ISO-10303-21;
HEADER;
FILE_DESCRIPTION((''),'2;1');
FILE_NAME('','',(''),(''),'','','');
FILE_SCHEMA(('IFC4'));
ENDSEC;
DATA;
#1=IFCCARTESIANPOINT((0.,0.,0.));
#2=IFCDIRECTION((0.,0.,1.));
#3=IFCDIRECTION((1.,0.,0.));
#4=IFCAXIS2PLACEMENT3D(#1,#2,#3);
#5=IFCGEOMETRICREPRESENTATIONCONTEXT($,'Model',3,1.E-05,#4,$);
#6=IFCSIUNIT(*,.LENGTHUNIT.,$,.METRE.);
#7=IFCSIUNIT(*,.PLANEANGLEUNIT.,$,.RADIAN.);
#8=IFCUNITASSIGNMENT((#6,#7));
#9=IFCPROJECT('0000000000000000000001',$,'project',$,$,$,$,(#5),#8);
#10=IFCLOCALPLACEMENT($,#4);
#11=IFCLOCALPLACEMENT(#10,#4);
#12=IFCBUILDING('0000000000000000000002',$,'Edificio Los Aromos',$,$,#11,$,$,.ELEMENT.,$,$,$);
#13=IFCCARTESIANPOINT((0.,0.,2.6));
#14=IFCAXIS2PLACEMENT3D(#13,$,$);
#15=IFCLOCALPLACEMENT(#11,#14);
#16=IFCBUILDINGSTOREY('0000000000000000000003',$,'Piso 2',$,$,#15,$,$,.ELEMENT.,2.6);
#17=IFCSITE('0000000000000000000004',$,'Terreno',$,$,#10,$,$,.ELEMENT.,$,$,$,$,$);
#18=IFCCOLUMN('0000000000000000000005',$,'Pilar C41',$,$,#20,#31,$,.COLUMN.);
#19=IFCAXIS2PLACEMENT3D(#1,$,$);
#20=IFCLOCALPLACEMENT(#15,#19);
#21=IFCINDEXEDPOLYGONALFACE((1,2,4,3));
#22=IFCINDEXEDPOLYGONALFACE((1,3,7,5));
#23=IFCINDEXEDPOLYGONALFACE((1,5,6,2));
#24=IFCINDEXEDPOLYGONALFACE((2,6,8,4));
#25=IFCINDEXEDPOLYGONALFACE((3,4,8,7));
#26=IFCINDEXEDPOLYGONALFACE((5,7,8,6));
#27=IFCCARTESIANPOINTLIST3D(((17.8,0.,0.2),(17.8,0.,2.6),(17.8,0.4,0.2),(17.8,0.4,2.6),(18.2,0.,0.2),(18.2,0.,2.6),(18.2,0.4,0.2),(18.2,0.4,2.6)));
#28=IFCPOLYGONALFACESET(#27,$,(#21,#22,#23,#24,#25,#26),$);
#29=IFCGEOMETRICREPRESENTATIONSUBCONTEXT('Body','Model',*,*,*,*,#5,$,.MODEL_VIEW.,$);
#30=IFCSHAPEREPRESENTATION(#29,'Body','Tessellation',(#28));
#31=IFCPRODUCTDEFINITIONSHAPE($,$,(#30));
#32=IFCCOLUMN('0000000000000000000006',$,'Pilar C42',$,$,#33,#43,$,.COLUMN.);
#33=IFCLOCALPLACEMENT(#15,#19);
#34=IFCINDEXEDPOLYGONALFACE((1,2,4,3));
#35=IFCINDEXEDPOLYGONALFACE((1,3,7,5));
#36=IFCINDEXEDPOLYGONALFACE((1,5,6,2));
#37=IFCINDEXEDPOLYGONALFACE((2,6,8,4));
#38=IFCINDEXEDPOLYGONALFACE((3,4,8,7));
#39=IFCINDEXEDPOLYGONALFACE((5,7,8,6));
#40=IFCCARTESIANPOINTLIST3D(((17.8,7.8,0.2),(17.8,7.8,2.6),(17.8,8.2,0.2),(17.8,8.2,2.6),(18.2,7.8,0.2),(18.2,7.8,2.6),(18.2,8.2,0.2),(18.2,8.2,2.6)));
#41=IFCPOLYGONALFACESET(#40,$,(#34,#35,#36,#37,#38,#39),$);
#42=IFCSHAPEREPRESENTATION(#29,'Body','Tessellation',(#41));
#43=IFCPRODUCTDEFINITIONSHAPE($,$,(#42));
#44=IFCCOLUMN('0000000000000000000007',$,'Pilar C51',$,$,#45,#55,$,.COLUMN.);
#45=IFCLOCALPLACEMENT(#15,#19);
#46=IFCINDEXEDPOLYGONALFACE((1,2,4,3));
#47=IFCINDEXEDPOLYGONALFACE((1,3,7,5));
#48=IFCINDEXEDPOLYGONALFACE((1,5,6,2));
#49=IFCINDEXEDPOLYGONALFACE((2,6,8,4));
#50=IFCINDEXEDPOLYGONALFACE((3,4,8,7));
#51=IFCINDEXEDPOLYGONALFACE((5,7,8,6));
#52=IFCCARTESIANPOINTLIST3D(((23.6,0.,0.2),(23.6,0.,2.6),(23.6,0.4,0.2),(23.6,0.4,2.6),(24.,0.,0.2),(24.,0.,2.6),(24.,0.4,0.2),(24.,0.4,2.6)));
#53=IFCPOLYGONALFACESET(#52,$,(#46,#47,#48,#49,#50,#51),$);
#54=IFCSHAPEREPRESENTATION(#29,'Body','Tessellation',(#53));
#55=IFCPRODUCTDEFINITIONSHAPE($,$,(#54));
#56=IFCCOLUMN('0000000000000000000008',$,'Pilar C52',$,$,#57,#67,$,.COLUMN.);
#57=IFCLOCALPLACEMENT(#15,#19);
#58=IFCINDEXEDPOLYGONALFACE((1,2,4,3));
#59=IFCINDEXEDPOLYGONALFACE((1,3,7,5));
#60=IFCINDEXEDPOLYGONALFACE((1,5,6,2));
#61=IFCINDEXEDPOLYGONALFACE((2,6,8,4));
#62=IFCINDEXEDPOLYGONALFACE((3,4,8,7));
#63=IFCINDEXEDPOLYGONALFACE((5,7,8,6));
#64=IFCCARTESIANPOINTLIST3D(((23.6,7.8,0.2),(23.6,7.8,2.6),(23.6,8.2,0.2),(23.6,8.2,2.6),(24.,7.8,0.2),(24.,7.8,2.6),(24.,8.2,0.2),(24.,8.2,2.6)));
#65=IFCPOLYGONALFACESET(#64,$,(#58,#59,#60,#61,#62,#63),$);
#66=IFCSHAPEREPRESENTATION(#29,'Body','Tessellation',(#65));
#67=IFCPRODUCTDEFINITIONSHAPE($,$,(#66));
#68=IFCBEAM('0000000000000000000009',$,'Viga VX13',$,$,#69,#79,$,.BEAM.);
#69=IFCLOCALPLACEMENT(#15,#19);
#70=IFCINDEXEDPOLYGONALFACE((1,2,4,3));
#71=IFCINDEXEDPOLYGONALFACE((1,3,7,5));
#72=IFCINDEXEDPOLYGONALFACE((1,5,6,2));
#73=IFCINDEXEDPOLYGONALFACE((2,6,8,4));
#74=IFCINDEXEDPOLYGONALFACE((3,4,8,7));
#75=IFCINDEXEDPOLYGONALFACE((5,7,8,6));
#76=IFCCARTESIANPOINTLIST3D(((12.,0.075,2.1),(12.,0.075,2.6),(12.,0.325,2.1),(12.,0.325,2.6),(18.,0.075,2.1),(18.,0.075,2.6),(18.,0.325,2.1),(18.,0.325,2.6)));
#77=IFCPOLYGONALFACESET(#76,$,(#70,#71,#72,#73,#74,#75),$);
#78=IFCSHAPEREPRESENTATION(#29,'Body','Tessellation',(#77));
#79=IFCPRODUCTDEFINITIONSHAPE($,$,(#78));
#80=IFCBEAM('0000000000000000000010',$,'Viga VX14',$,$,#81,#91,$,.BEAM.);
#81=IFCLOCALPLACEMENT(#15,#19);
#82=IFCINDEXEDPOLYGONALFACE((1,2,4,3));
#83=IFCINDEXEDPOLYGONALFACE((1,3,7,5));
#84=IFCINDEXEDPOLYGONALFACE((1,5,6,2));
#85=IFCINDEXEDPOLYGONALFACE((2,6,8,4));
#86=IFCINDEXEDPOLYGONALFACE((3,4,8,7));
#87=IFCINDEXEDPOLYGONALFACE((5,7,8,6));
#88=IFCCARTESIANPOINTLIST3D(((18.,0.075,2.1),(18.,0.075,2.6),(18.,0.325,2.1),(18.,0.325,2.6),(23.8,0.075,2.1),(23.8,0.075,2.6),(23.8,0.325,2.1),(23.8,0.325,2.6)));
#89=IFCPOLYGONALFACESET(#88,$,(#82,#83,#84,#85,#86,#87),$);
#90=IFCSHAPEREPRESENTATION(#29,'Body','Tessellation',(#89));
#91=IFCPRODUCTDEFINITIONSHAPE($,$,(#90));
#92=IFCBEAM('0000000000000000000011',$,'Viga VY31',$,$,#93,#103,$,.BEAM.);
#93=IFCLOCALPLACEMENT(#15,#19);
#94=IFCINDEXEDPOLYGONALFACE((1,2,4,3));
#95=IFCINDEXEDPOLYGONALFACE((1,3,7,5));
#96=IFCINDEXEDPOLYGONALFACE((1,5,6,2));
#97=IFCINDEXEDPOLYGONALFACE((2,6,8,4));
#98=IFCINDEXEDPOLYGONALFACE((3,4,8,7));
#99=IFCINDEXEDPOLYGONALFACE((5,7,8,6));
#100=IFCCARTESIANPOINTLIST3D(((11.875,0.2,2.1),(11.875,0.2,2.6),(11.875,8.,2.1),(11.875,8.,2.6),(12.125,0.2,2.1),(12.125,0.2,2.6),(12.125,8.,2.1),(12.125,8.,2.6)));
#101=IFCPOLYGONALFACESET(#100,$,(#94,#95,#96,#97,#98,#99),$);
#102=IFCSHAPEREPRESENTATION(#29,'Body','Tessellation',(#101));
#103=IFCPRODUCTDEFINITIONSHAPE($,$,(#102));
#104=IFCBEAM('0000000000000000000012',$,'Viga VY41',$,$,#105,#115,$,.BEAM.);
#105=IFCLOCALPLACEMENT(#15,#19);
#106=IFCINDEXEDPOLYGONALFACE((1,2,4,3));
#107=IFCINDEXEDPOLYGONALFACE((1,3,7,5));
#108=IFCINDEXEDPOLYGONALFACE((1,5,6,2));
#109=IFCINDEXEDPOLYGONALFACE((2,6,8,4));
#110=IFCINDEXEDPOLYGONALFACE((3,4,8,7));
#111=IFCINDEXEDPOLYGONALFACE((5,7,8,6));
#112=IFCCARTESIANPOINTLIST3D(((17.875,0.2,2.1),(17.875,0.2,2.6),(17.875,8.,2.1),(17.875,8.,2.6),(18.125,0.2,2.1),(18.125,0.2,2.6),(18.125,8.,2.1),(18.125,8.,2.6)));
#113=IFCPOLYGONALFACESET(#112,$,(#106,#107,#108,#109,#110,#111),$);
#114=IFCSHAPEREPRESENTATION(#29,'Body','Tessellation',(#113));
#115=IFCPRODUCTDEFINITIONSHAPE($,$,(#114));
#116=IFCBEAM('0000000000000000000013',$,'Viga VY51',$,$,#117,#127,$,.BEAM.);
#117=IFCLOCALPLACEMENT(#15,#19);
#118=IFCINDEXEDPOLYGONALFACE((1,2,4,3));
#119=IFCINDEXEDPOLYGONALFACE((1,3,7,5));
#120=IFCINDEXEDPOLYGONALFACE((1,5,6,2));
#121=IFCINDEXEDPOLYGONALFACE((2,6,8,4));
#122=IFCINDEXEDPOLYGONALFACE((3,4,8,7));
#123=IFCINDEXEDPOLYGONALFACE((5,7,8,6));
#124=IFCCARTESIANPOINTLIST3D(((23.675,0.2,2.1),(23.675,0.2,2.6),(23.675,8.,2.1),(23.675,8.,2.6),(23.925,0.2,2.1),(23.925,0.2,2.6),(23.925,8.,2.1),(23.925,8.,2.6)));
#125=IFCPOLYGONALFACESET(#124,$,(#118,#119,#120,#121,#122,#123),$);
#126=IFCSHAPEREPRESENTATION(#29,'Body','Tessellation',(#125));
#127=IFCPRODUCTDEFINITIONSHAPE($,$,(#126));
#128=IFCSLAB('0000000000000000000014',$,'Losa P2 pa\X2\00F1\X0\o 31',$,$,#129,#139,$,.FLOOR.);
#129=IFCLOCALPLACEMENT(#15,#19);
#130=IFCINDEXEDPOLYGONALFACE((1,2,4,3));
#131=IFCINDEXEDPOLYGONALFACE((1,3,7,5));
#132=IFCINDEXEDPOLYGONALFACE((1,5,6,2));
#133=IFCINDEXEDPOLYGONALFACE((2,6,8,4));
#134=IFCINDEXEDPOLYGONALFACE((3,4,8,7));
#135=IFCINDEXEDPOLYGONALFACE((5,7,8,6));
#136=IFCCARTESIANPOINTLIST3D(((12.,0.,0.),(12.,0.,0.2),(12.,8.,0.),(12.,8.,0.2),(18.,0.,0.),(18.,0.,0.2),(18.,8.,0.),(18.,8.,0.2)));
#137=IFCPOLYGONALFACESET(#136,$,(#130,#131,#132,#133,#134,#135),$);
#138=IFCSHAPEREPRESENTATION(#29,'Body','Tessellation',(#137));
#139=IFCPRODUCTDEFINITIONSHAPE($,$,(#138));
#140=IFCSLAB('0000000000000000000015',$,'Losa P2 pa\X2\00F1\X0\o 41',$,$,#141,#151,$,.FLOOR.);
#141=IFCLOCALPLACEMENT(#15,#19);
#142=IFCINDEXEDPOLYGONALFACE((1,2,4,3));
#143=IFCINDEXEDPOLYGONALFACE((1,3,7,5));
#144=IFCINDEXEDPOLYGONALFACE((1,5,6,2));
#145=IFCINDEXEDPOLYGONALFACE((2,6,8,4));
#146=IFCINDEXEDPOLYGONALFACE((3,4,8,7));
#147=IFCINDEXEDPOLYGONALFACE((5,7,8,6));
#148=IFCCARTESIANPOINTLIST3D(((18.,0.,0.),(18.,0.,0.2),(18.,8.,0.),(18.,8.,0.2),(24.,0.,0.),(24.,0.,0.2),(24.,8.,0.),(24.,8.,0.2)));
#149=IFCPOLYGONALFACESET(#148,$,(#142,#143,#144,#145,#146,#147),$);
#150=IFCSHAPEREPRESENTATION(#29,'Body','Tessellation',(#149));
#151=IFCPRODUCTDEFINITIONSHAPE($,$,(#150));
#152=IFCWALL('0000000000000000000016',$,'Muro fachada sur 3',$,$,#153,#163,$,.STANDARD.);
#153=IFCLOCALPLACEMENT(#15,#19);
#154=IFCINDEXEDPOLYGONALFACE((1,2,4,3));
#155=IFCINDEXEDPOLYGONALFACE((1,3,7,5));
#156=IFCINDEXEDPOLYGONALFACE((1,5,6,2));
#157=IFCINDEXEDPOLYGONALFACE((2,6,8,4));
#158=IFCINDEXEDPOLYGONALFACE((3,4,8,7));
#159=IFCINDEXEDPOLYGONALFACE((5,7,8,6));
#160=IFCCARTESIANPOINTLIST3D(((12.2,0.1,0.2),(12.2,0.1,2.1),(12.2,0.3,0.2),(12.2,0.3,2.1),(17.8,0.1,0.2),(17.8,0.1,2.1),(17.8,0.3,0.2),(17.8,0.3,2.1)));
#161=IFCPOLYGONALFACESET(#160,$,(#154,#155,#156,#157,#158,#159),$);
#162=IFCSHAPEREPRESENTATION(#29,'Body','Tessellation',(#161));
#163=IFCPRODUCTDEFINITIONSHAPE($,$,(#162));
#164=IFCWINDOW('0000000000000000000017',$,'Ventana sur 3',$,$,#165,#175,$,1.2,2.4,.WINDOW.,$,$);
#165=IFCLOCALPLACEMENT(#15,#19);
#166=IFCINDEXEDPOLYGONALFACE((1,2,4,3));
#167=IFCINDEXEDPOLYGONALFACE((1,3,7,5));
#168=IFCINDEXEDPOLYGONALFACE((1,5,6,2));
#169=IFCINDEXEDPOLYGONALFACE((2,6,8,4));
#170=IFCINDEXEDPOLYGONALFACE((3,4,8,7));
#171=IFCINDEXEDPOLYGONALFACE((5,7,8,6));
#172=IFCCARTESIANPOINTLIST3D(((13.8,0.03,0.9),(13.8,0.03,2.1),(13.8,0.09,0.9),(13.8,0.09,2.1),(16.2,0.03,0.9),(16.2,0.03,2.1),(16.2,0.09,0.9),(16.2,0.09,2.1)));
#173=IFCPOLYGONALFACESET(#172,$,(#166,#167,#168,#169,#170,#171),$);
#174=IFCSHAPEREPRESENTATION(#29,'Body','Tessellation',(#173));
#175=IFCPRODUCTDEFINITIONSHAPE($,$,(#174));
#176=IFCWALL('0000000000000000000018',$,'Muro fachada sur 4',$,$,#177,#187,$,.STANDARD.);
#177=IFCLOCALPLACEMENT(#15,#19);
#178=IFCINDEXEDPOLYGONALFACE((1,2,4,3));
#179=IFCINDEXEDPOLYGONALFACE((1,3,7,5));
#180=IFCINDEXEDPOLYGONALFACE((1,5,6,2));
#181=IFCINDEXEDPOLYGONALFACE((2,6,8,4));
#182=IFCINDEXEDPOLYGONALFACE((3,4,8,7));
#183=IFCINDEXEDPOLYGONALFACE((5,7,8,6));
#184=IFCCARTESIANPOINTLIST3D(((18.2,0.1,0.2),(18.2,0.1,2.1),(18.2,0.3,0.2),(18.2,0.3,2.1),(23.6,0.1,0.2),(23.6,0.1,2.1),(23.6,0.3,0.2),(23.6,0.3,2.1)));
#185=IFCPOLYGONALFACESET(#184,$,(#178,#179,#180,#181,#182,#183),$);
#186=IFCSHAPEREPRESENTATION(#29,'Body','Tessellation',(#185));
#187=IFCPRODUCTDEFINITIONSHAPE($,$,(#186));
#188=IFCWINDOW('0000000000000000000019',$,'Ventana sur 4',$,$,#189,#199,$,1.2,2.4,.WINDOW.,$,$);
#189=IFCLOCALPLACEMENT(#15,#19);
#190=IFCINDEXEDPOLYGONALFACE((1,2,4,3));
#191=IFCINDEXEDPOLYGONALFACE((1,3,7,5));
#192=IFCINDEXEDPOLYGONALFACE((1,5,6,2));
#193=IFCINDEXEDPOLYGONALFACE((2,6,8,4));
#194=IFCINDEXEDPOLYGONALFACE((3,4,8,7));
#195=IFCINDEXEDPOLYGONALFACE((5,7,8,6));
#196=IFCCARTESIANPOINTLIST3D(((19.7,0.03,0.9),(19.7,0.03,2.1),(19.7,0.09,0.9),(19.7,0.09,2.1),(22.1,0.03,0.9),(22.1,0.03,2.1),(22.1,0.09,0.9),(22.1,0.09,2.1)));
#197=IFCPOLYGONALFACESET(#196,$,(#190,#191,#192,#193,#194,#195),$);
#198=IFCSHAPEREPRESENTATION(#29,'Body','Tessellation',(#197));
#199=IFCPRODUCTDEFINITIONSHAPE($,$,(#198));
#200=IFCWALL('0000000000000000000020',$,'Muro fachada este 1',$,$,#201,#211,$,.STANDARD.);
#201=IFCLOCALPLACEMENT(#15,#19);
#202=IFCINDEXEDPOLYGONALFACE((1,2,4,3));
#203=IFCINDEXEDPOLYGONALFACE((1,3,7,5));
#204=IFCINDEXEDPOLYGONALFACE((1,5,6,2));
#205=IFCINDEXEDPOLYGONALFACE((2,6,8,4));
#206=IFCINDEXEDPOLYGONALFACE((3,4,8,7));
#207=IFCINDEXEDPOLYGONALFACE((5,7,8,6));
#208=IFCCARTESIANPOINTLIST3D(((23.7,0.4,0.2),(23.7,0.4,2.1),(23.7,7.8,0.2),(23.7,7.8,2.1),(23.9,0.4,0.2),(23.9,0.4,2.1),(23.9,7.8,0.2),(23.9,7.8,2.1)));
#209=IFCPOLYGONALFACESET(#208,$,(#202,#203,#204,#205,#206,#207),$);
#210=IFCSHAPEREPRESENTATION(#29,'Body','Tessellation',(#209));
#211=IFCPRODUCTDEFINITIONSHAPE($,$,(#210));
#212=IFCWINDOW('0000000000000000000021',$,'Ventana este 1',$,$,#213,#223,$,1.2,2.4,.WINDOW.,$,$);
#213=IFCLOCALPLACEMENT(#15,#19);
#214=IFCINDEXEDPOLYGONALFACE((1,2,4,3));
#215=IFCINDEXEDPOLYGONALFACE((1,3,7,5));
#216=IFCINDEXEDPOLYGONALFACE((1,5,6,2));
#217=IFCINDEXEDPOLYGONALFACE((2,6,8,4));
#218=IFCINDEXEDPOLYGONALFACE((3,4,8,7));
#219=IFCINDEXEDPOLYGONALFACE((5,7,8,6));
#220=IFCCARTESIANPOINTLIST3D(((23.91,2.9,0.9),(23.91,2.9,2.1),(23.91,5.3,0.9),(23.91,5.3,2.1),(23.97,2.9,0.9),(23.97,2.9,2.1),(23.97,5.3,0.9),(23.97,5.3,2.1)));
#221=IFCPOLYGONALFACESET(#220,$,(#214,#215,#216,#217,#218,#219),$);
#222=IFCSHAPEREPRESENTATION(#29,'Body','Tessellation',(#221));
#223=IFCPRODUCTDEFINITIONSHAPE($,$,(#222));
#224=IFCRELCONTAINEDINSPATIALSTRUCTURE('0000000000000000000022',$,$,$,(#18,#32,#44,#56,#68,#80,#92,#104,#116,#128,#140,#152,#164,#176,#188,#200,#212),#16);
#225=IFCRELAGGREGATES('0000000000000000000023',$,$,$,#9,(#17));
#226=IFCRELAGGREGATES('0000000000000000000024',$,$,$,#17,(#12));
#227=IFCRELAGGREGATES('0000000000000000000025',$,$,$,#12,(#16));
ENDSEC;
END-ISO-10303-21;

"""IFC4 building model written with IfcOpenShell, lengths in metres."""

from ifc_helpers import new_model, si_unit, frame, frame_2d, origin_with_axes, place, context, subcontext, project, spatial, rectangle, extrude, element, save


model = new_model("IFC4")

# Units and contexts
model_context = context("Model", 3, precision=1e-05, world=origin_with_axes())
body_context = subcontext(model_context, "Body", "Model", "MODEL_VIEW")
ifc_project = project(units=[si_unit("LENGTHUNIT", "METRE"), si_unit("PLANEANGLEUNIT", "RADIAN")], contexts=[model_context])

# Site, building, storey
site_placement = place(None, origin_with_axes())
site = spatial("IfcSite", under=ifc_project, at=site_placement, Name="Terreno", CompositionType="ELEMENT")
building_placement = place(site_placement, origin_with_axes())
building = spatial("IfcBuilding", under=site, at=building_placement, Name="Edificio Los Aromos", CompositionType="ELEMENT")
storey_placement = place(building_placement, frame((0.0, 0.0, 2.6)))
storey = spatial("IfcBuildingStorey", under=building, at=storey_placement, Name="Piso 2", CompositionType="ELEMENT", Elevation=2.6)

# Columns
for number, where, name in (
    (1, (17.8, 0.0, 0.2), "Pilar C41"),
    (2, (17.8, 7.8, 0.2), "Pilar C42"),
    (3, (23.6, 0.0, 0.2), "Pilar C51"),
    (4, (23.6, 7.8, 0.2), "Pilar C52"),
):
    element("IfcColumn", number, at=place(storey_placement, frame(where)), inside=storey, Name=name, PredefinedType="COLUMN", context=body_context, shape_type="SweptSolid", body=[
        extrude(rectangle(XDim=0.4, YDim=0.4, at=frame_2d((0.2, 0.2))), origin_with_axes(), (0.0, 0.0, 1.0), 2.4),
    ])

# Beams
beam_1_placement = place(storey_placement, frame((12.0, 0.075, 2.1)))
element("IfcBeam", 5, at=beam_1_placement, inside=storey, Name="Viga VX13", PredefinedType="BEAM", context=body_context, shape_type="SweptSolid", body=[
    extrude(rectangle(XDim=6.0, YDim=0.25, at=frame_2d((3.0, 0.125))), origin_with_axes(), (0.0, 0.0, 1.0), 0.5),
])
beam_2_placement = place(storey_placement, frame((18.0, 0.075, 2.1)))
element("IfcBeam", 6, at=beam_2_placement, inside=storey, Name="Viga VX14", PredefinedType="BEAM", context=body_context, shape_type="SweptSolid", body=[
    extrude(rectangle(XDim=5.8, YDim=0.25, at=frame_2d((2.9, 0.125))), origin_with_axes(), (0.0, 0.0, 1.0), 0.5),
])
for number, where, name in (
    (7, (11.875, 0.2, 2.1), "Viga VY31"),
    (8, (17.875, 0.2, 2.1), "Viga VY41"),
    (9, (23.675, 0.2, 2.1), "Viga VY51"),
):
    element("IfcBeam", number, at=place(storey_placement, frame(where)), inside=storey, Name=name, PredefinedType="BEAM", context=body_context, shape_type="SweptSolid", body=[
        extrude(rectangle(XDim=0.25, YDim=7.8, at=frame_2d((0.125, 3.9))), origin_with_axes(), (0.0, 0.0, 1.0), 0.5),
    ])

# Slabs
for number, where, name in (
    (10, (12.0, 0.0, 0.0), "Losa P2 paño 31"),
    (11, (18.0, 0.0, 0.0), "Losa P2 paño 41"),
):
    element("IfcSlab", number, at=place(storey_placement, frame(where)), inside=storey, Name=name, PredefinedType="FLOOR", context=body_context, shape_type="SweptSolid", body=[
        extrude(rectangle(XDim=6.0, YDim=8.0, at=frame_2d((3.0, 4.0))), origin_with_axes(), (0.0, 0.0, 1.0), 0.2),
    ])

# Wall
wall_1_placement = place(storey_placement, frame((12.2, 0.1, 0.2)))
element("IfcWall", 12, at=wall_1_placement, inside=storey, Name="Muro fachada sur 3", PredefinedType="STANDARD", context=body_context, shape_type="SweptSolid", body=[
    extrude(rectangle(XDim=5.6, YDim=0.2, at=frame_2d((2.8, 0.1))), origin_with_axes(), (0.0, 0.0, 1.0), 1.9),
])

# Window
window_1_placement = place(storey_placement, frame((13.8, 0.03, 0.9)))
element("IfcWindow", 13, at=window_1_placement, inside=storey, Name="Ventana sur 3", OverallHeight=1.2, OverallWidth=2.4, PredefinedType="WINDOW", context=body_context, shape_type="SweptSolid", body=[
    extrude(rectangle(XDim=2.4, YDim=0.06, at=frame_2d((1.2, 0.03))), origin_with_axes(), (0.0, 0.0, 1.0), 1.2),
])

# Wall
wall_2_placement = place(storey_placement, frame((18.2, 0.1, 0.2)))
element("IfcWall", 14, at=wall_2_placement, inside=storey, Name="Muro fachada sur 4", PredefinedType="STANDARD", context=body_context, shape_type="SweptSolid", body=[
    extrude(rectangle(XDim=5.4, YDim=0.2, at=frame_2d((2.7, 0.1))), origin_with_axes(), (0.0, 0.0, 1.0), 1.9),
])

# Window
window_2_placement = place(storey_placement, frame((19.7, 0.03, 0.9)))
element("IfcWindow", 15, at=window_2_placement, inside=storey, Name="Ventana sur 4", OverallHeight=1.2, OverallWidth=2.4, PredefinedType="WINDOW", context=body_context, shape_type="SweptSolid", body=[
    extrude(rectangle(XDim=2.4, YDim=0.06, at=frame_2d((1.2, 0.03))), origin_with_axes(), (0.0, 0.0, 1.0), 1.2),
])

# Wall
wall_3_placement = place(storey_placement, frame((23.7, 0.4, 0.2)))
element("IfcWall", 16, at=wall_3_placement, inside=storey, Name="Muro fachada este 1", PredefinedType="STANDARD", context=body_context, shape_type="SweptSolid", body=[
    extrude(rectangle(XDim=0.2, YDim=7.4, at=frame_2d((0.1, 3.7))), origin_with_axes(), (0.0, 0.0, 1.0), 1.9),
])

# Window
window_3_placement = place(storey_placement, frame((23.91, 2.9, 0.9)))
element("IfcWindow", 17, at=window_3_placement, inside=storey, Name="Ventana este 1", OverallHeight=1.2, OverallWidth=2.4, PredefinedType="WINDOW", context=body_context, shape_type="SweptSolid", body=[
    extrude(rectangle(XDim=0.06, YDim=2.4, at=frame_2d((0.03, 1.2))), origin_with_axes(), (0.0, 0.0, 1.0), 1.2),
])

save(model, "model.ifc")
